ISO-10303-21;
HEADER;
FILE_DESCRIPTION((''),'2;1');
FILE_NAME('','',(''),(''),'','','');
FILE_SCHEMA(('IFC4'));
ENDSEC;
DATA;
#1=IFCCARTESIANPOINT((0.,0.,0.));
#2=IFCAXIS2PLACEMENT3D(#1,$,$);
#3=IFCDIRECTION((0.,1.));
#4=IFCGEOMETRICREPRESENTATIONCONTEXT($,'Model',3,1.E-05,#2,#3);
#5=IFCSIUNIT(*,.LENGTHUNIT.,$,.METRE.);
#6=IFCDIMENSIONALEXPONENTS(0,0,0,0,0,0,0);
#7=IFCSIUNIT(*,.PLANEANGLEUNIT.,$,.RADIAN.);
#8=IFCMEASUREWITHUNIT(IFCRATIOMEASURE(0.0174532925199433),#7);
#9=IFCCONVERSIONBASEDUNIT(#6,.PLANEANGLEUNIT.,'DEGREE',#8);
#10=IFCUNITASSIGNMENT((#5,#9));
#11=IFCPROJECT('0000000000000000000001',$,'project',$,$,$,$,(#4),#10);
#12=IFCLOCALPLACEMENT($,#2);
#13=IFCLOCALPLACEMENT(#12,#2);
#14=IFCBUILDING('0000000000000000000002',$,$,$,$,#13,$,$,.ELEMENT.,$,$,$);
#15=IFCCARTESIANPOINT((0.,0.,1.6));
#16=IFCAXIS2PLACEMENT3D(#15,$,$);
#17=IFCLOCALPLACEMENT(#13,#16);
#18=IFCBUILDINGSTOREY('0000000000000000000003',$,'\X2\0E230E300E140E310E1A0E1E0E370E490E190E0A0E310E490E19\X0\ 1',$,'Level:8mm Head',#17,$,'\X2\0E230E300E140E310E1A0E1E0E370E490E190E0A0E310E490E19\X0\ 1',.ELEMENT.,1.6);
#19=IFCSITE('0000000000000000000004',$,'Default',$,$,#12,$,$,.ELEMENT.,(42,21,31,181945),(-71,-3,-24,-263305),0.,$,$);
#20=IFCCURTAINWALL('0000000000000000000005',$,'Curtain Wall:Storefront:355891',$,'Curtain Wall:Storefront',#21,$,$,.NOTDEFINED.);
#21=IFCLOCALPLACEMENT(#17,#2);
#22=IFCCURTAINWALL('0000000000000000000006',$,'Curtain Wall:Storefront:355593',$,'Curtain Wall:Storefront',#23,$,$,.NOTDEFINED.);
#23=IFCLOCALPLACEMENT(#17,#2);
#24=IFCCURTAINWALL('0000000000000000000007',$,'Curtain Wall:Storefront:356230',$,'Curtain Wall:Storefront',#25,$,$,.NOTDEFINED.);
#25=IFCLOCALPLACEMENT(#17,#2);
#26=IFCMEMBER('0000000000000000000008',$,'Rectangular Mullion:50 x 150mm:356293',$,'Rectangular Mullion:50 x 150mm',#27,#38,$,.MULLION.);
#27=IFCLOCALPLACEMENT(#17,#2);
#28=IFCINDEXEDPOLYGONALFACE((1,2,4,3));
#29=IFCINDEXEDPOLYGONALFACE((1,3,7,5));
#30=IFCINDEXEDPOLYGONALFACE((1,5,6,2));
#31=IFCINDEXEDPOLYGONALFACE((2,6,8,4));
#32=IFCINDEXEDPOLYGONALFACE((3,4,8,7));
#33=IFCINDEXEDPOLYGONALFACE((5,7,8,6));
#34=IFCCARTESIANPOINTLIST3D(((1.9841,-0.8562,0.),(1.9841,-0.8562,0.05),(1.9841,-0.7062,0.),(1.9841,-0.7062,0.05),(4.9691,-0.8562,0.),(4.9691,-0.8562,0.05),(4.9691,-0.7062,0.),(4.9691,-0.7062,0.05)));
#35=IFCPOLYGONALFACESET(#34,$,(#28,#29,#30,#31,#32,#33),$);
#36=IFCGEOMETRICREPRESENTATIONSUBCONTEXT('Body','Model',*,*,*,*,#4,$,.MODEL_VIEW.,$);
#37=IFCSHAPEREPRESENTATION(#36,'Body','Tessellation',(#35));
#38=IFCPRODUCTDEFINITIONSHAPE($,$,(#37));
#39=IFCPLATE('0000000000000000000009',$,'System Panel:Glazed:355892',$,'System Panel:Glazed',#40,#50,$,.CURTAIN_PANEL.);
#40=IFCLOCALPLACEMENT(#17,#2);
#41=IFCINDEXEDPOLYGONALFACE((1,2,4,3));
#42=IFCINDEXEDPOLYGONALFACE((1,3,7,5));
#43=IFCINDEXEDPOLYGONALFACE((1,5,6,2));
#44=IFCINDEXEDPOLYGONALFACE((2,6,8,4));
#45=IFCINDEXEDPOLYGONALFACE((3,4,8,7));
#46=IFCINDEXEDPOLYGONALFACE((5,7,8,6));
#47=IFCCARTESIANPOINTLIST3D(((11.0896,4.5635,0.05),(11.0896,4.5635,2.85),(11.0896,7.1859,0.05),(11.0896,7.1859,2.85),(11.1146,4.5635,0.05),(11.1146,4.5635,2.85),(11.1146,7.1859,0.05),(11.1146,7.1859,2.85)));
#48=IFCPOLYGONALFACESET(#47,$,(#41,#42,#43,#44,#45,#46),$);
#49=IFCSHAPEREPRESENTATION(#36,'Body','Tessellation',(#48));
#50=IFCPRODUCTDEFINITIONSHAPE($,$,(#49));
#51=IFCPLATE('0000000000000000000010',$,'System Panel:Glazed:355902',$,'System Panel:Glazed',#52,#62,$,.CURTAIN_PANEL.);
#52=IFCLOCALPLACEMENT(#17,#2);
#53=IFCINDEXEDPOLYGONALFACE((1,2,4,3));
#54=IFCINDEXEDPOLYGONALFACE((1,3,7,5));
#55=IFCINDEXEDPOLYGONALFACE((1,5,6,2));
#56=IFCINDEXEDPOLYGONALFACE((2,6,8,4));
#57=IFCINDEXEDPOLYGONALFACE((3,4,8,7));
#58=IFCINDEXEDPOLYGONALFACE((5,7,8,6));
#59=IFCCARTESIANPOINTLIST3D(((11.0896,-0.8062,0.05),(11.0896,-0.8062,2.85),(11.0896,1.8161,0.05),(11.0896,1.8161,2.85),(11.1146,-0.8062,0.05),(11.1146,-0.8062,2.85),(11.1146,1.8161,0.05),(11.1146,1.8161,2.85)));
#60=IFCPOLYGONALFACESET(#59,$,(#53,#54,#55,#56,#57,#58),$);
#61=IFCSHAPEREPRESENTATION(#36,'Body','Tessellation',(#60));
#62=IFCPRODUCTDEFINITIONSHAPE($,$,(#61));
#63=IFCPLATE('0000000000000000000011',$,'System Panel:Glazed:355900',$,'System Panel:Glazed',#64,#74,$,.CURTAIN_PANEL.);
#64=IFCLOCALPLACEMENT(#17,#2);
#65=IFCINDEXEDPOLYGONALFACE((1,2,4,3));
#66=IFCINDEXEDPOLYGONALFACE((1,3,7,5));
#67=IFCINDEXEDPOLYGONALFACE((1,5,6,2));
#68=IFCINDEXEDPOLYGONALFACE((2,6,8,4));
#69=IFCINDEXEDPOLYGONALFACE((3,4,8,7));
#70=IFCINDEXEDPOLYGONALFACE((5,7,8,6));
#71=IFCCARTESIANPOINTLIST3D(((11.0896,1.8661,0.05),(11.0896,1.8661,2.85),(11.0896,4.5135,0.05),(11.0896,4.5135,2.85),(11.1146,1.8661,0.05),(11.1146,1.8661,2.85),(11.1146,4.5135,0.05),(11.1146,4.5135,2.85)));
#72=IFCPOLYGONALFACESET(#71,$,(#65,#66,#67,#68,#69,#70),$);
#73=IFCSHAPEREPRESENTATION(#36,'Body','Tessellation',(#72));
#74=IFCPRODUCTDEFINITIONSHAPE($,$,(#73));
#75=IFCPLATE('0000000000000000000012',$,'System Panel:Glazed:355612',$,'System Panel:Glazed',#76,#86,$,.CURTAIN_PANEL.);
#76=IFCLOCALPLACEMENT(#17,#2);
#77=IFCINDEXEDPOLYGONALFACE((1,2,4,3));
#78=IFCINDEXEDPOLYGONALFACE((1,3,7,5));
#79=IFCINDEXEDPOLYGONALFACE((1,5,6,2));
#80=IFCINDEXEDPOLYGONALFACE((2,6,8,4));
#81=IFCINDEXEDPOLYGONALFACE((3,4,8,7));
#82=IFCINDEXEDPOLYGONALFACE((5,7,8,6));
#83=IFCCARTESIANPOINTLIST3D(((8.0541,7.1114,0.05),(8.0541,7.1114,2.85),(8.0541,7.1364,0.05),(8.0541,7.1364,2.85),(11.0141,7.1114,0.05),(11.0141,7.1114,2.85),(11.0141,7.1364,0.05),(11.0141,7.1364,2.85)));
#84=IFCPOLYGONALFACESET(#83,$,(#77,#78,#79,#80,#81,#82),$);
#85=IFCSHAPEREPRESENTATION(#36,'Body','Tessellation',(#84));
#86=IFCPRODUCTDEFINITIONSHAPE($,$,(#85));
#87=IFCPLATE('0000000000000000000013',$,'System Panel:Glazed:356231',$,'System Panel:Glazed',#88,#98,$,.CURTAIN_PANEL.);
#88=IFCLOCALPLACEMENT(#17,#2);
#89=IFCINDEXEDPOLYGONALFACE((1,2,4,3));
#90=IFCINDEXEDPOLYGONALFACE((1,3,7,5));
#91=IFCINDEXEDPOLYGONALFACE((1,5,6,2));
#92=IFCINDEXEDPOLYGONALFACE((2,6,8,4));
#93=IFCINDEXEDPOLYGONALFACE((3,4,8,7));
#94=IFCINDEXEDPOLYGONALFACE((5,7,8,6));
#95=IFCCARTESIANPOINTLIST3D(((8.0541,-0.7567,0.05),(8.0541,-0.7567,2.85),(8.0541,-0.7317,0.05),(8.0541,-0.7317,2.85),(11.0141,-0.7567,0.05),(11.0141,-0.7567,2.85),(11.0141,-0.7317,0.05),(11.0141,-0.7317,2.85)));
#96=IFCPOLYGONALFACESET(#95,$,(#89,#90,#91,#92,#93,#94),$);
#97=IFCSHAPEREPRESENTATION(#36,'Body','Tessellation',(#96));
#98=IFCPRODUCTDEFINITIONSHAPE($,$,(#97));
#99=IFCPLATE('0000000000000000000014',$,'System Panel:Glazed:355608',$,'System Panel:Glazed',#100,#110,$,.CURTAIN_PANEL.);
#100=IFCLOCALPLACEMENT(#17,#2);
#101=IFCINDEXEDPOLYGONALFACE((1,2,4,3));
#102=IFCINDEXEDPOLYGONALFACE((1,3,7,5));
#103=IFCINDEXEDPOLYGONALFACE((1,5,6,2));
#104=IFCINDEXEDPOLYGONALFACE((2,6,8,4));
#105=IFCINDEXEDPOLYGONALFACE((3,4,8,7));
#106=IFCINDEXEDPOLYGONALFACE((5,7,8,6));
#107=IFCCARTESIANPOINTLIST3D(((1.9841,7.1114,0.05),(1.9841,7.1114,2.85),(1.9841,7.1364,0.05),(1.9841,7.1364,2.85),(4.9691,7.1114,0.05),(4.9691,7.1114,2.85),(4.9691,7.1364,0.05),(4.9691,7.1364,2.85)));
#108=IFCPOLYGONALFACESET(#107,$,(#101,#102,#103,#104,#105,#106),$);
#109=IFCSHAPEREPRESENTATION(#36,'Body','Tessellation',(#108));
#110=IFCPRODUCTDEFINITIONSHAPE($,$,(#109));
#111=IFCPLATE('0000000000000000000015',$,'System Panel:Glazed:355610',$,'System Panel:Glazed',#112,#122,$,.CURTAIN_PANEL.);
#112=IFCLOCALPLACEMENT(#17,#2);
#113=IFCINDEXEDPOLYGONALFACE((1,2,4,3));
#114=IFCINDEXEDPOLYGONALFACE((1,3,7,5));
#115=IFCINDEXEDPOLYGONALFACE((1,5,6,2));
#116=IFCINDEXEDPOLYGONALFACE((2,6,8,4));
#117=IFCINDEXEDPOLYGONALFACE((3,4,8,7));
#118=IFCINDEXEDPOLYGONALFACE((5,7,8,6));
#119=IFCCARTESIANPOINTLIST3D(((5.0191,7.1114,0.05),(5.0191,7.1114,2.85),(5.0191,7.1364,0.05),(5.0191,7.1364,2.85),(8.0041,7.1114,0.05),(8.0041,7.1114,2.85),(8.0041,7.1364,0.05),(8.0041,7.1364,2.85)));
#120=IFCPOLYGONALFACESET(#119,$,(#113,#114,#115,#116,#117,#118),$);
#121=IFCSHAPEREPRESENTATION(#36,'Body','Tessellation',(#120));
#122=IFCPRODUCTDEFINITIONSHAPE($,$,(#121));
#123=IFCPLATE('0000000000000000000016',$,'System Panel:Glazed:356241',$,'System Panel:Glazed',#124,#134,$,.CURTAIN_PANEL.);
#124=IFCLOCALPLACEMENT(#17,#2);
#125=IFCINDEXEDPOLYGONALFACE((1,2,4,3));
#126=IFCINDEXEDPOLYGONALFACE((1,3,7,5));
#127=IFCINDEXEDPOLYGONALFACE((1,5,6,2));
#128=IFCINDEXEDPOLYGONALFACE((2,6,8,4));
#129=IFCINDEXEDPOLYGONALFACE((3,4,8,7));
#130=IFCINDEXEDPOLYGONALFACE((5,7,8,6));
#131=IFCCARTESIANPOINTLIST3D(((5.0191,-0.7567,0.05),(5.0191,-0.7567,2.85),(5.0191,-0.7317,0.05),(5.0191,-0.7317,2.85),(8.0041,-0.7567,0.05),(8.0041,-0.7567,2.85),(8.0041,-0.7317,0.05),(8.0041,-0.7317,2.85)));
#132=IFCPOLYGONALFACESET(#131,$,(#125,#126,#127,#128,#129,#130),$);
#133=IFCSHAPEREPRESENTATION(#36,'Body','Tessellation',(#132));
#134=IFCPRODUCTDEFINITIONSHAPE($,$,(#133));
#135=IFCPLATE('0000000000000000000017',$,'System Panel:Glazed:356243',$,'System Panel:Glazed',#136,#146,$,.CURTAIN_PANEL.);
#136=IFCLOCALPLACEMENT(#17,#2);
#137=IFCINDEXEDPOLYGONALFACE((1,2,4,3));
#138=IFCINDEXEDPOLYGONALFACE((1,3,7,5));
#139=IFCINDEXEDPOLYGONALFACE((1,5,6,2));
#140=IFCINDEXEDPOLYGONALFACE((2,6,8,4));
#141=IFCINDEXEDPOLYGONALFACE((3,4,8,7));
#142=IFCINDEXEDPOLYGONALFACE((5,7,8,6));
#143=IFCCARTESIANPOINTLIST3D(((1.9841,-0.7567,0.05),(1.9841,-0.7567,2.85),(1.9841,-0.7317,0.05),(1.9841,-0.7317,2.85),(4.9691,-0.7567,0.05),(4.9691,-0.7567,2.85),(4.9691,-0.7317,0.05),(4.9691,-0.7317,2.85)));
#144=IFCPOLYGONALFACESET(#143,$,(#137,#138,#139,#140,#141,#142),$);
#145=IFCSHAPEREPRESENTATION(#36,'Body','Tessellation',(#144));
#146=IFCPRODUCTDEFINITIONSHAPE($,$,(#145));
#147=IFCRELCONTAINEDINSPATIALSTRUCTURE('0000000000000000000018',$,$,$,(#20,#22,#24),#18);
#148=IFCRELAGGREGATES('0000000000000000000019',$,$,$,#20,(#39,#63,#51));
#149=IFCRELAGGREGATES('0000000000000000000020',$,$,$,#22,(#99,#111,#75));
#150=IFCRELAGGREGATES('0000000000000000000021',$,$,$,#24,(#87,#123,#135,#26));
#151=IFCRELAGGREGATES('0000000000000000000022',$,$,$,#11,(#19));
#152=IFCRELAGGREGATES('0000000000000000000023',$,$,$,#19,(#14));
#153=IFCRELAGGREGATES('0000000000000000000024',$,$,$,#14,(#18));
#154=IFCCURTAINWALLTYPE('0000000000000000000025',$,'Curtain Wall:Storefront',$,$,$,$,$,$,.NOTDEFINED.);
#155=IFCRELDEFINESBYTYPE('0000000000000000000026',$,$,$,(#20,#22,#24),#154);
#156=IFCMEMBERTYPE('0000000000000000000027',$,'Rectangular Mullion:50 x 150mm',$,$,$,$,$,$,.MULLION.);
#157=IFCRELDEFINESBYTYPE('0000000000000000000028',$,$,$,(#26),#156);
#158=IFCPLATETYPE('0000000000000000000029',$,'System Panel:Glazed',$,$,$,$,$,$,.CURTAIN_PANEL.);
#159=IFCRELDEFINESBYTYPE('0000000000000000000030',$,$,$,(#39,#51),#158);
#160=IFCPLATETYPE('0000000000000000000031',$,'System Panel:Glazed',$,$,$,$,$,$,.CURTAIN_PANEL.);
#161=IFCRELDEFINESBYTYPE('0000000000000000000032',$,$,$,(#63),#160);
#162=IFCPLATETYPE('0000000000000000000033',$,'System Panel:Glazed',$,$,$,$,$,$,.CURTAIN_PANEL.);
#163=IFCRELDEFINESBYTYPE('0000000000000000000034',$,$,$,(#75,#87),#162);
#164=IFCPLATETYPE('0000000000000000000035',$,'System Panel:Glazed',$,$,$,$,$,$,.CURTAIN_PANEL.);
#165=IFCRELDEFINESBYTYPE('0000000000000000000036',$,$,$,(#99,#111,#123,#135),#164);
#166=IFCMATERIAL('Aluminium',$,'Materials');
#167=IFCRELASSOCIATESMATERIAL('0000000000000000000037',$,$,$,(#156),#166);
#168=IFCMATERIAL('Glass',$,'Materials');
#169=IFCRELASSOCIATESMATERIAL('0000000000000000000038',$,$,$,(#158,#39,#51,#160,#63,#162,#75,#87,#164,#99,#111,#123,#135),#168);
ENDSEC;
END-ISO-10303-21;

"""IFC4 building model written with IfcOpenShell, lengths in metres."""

from ifc_helpers import new_model, entity, si_unit, converted_unit, direction, frame, origin, place, context, subcontext, project, spatial, indexed_curve, outline, extrude, source, transform, mapped, material, type_object, type_shapes, element, aggregate, save


model = new_model("IFC4")

# Units and contexts
model_context = context("Model", 3, precision=1e-05, world=origin(), true_north=direction((0.0, 1.0)))
body_context = subcontext(model_context, "Body", "Model", "MODEL_VIEW")
ifc_project = project(units=[si_unit("LENGTHUNIT", "METRE"), converted_unit("PLANEANGLEUNIT", "DEGREE", entity("IfcRatioMeasure", 0.0174532925199433), si_unit("PLANEANGLEUNIT", "RADIAN"), dimensions=[0, 0, 0, 0, 0, 0, 0])], contexts=[model_context])

# Site, building, storey
site_placement = place(None, origin())
site = spatial("IfcSite", under=ifc_project, at=site_placement, Name="Default", CompositionType="ELEMENT", RefLatitude=(42, 21, 31, 181945), RefLongitude=(-71, -3, -24, -263305), RefElevation=0.0)
building_placement = place(site_placement, origin())
building = spatial("IfcBuilding", under=site, at=building_placement, CompositionType="ELEMENT")
storey_placement = place(building_placement, frame((0.0, 0.0, 1.6)))
storey = spatial("IfcBuildingStorey", under=building, at=storey_placement, Name="ระดับพื้นชั้น 1", ObjectType="Level:8mm Head", LongName="ระดับพื้นชั้น 1", CompositionType="ELEMENT", Elevation=1.6)

# Curtain wall
curtain_wall_type = type_object("IfcCurtainWallType", Name="Curtain Wall:Storefront", PredefinedType="NOTDEFINED")
curtain_wall_1_placement = place(storey_placement, frame((0.0, 0.0, -1.6)))
curtain_wall_1 = element("IfcCurtainWall", 1, at=curtain_wall_1_placement, inside=storey, type_object=curtain_wall_type, Name="Curtain Wall:Storefront:355891", ObjectType="Curtain Wall:Storefront", PredefinedType="NOTDEFINED")
ifc_material_1 = material(Name="Aluminium", Category="Materials")

# Curtain wall
curtain_wall_2_placement = place(storey_placement, frame((0.0, 0.0, -1.6)))
curtain_wall_2 = element("IfcCurtainWall", 2, at=curtain_wall_2_placement, inside=storey, type_object=curtain_wall_type, Name="Curtain Wall:Storefront:355593", ObjectType="Curtain Wall:Storefront", PredefinedType="NOTDEFINED")

# Curtain wall
curtain_wall_3_placement = place(storey_placement, frame((0.0, 0.0, -1.6)))
curtain_wall_3 = element("IfcCurtainWall", 3, at=curtain_wall_3_placement, inside=storey, type_object=curtain_wall_type, Name="Curtain Wall:Storefront:356230", ObjectType="Curtain Wall:Storefront", PredefinedType="NOTDEFINED")

# Member
member_type_1 = type_object("IfcMemberType", Name="Rectangular Mullion:50 x 150mm", PredefinedType="MULLION", material=ifc_material_1)
shared_shape_1 = source(origin(), body_context, "Body", "SweptSolid", [
    extrude(outline(indexed_curve([(-0.075, -0.025), (0.075, -0.025), (0.075, 0.025), (-0.075, 0.025), (-0.075, -0.025)], self_intersect=False)), frame((-0.025, 0.0, -2.985), z_axis=(0.0, 0.0, 1.0), x_axis=(0.0, -1.0, 0.0)), (0.0, 0.0, 1.0), 2.985),
])
type_shapes(member_type_1, [shared_shape_1])
member_1_placement = place(curtain_wall_3_placement, frame((4.9691, -0.7812, 1.6), z_axis=(1.0, 0.0, 0.0), x_axis=(0.0, 0.0, -1.0)))
member_1 = element("IfcMember", 4, at=member_1_placement, type_object=member_type_1, Name="Rectangular Mullion:50 x 150mm:356293", ObjectType="Rectangular Mullion:50 x 150mm", PredefinedType="MULLION", context=body_context, shape_type="MappedRepresentation", body=[
    mapped(shared_shape_1, transform((0.0, 0.0, 0.0), scale=1.0)),
])

# Plates
ifc_material_2 = material(Name="Glass", Category="Materials")
plate_type_1 = type_object("IfcPlateType", Name="System Panel:Glazed", PredefinedType="CURTAIN_PANEL", material=ifc_material_2)
shared_shape_2 = source(origin(), body_context, "Body", "SweptSolid", [
    extrude(outline(indexed_curve([(-0.0125, -1.3112), (0.0125, -1.3112), (0.0125, 1.3112), (-0.0125, 1.3112), (-0.0125, -1.3112)], self_intersect=False)), frame((0.0, -0.037, 0.0), z_axis=(0.0, 0.0, 1.0), x_axis=(0.0, 1.0, 0.0)), (0.0, 0.0, 1.0), 2.8),
])
type_shapes(plate_type_1, [shared_shape_2])
plate_1_placement = place(curtain_wall_1_placement, frame((11.1391, 5.8747, 1.65), z_axis=(0.0, 0.0, 1.0), x_axis=(0.0, -1.0, 0.0)))
plate_1 = element("IfcPlate", 5, at=plate_1_placement, type_object=plate_type_1, material=ifc_material_2, Name="System Panel:Glazed:355892", ObjectType="System Panel:Glazed", PredefinedType="CURTAIN_PANEL", context=body_context, shape_type="MappedRepresentation", body=[
    mapped(shared_shape_2, transform((0.0, 0.0, 0.0), scale=1.0)),
])
plate_2_placement = place(curtain_wall_1_placement, frame((11.1391, 0.5049, 1.65), z_axis=(0.0, 0.0, 1.0), x_axis=(0.0, -1.0, 0.0)))
plate_2 = element("IfcPlate", 6, at=plate_2_placement, type_object=plate_type_1, material=ifc_material_2, Name="System Panel:Glazed:355902", ObjectType="System Panel:Glazed", PredefinedType="CURTAIN_PANEL", context=body_context, shape_type="MappedRepresentation", body=[
    mapped(shared_shape_2, transform((0.0, 0.0, 0.0), scale=1.0)),
])
plate_type_2 = type_object("IfcPlateType", Name="System Panel:Glazed", PredefinedType="CURTAIN_PANEL", material=ifc_material_2)
shared_shape_3 = source(origin(), body_context, "Body", "SweptSolid", [
    extrude(outline(indexed_curve([(-0.0125, -1.3237), (0.0125, -1.3237), (0.0125, 1.3237), (-0.0125, 1.3237), (-0.0125, -1.3237)], self_intersect=False)), frame((0.0, -0.037, 0.0), z_axis=(0.0, 0.0, 1.0), x_axis=(0.0, 1.0, 0.0)), (0.0, 0.0, 1.0), 2.8),
])
type_shapes(plate_type_2, [shared_shape_3])
plate_3_placement = place(curtain_wall_1_placement, frame((11.1391, 3.1898, 1.65), z_axis=(0.0, 0.0, 1.0), x_axis=(0.0, -1.0, 0.0)))
plate_3 = element("IfcPlate", 7, at=plate_3_placement, type_object=plate_type_2, material=ifc_material_2, Name="System Panel:Glazed:355900", ObjectType="System Panel:Glazed", PredefinedType="CURTAIN_PANEL", context=body_context, shape_type="MappedRepresentation", body=[
    mapped(shared_shape_3, transform((0.0, 0.0, 0.0), scale=1.0)),
])
aggregate(curtain_wall_1, [plate_1, plate_3, plate_2])
plate_type_3 = type_object("IfcPlateType", Name="System Panel:Glazed", PredefinedType="CURTAIN_PANEL", material=ifc_material_2)
shared_shape_4 = source(origin(), body_context, "Body", "SweptSolid", [
    extrude(outline(indexed_curve([(-0.0125, -1.48), (0.0125, -1.48), (0.0125, 1.48), (-0.0125, 1.48), (-0.0125, -1.48)], self_intersect=False)), frame((0.0, -0.037, 0.0), z_axis=(0.0, 0.0, 1.0), x_axis=(0.0, 1.0, 0.0)), (0.0, 0.0, 1.0), 2.8),
])
type_shapes(plate_type_3, [shared_shape_4])
plate_4_placement = place(curtain_wall_2_placement, frame((9.5341, 7.1609, 1.65)))
plate_4 = element("IfcPlate", 8, at=plate_4_placement, type_object=plate_type_3, material=ifc_material_2, Name="System Panel:Glazed:355612", ObjectType="System Panel:Glazed", PredefinedType="CURTAIN_PANEL", context=body_context, shape_type="MappedRepresentation", body=[
    mapped(shared_shape_4, transform((0.0, 0.0, 0.0), scale=1.0)),
])
plate_5_placement = place(curtain_wall_3_placement, frame((9.5341, -0.7812, 1.65), z_axis=(0.0, 0.0, 1.0), x_axis=(-1.0, 0.0, 0.0)))
plate_5 = element("IfcPlate", 9, at=plate_5_placement, type_object=plate_type_3, material=ifc_material_2, Name="System Panel:Glazed:356231", ObjectType="System Panel:Glazed", PredefinedType="CURTAIN_PANEL", context=body_context, shape_type="MappedRepresentation", body=[
    mapped(shared_shape_4, transform((0.0, 0.0, 0.0), scale=1.0)),
])
plate_type_4 = type_object("IfcPlateType", Name="System Panel:Glazed", PredefinedType="CURTAIN_PANEL", material=ifc_material_2)
shared_shape_5 = source(origin(), body_context, "Body", "SweptSolid", [
    extrude(outline(indexed_curve([(-0.0125, -1.4925), (0.0125, -1.4925), (0.0125, 1.4925), (-0.0125, 1.4925), (-0.0125, -1.4925)], self_intersect=False)), frame((0.0, -0.037, 0.0), z_axis=(0.0, 0.0, 1.0), x_axis=(0.0, 1.0, 0.0)), (0.0, 0.0, 1.0), 2.8),
])
type_shapes(plate_type_4, [shared_shape_5])
plate_6_placement = place(curtain_wall_2_placement, frame((3.4766, 7.1609, 1.65)))
plate_6 = element("IfcPlate", 10, at=plate_6_placement, type_object=plate_type_4, material=ifc_material_2, Name="System Panel:Glazed:355608", ObjectType="System Panel:Glazed", PredefinedType="CURTAIN_PANEL", context=body_context, shape_type="MappedRepresentation", body=[
    mapped(shared_shape_5, transform((0.0, 0.0, 0.0), scale=1.0)),
])
plate_7_placement = place(curtain_wall_2_placement, frame((6.5116, 7.1609, 1.65)))
plate_7 = element("IfcPlate", 11, at=plate_7_placement, type_object=plate_type_4, material=ifc_material_2, Name="System Panel:Glazed:355610", ObjectType="System Panel:Glazed", PredefinedType="CURTAIN_PANEL", context=body_context, shape_type="MappedRepresentation", body=[
    mapped(shared_shape_5, transform((0.0, 0.0, 0.0), scale=1.0)),
])
aggregate(curtain_wall_2, [plate_6, plate_7, plate_4])
plate_8_placement = place(curtain_wall_3_placement, frame((6.5116, -0.7812, 1.65), z_axis=(0.0, 0.0, 1.0), x_axis=(-1.0, 0.0, 0.0)))
plate_8 = element("IfcPlate", 12, at=plate_8_placement, type_object=plate_type_4, material=ifc_material_2, Name="System Panel:Glazed:356241", ObjectType="System Panel:Glazed", PredefinedType="CURTAIN_PANEL", context=body_context, shape_type="MappedRepresentation", body=[
    mapped(shared_shape_5, transform((0.0, 0.0, 0.0), scale=1.0)),
])
plate_9_placement = place(curtain_wall_3_placement, frame((3.4766, -0.7812, 1.65), z_axis=(0.0, 0.0, 1.0), x_axis=(-1.0, 0.0, 0.0)))
plate_9 = element("IfcPlate", 13, at=plate_9_placement, type_object=plate_type_4, material=ifc_material_2, Name="System Panel:Glazed:356243", ObjectType="System Panel:Glazed", PredefinedType="CURTAIN_PANEL", context=body_context, shape_type="MappedRepresentation", body=[
    mapped(shared_shape_5, transform((0.0, 0.0, 0.0), scale=1.0)),
])
aggregate(curtain_wall_3, [plate_5, plate_8, plate_9, member_1])

save(model, "model.ifc")
